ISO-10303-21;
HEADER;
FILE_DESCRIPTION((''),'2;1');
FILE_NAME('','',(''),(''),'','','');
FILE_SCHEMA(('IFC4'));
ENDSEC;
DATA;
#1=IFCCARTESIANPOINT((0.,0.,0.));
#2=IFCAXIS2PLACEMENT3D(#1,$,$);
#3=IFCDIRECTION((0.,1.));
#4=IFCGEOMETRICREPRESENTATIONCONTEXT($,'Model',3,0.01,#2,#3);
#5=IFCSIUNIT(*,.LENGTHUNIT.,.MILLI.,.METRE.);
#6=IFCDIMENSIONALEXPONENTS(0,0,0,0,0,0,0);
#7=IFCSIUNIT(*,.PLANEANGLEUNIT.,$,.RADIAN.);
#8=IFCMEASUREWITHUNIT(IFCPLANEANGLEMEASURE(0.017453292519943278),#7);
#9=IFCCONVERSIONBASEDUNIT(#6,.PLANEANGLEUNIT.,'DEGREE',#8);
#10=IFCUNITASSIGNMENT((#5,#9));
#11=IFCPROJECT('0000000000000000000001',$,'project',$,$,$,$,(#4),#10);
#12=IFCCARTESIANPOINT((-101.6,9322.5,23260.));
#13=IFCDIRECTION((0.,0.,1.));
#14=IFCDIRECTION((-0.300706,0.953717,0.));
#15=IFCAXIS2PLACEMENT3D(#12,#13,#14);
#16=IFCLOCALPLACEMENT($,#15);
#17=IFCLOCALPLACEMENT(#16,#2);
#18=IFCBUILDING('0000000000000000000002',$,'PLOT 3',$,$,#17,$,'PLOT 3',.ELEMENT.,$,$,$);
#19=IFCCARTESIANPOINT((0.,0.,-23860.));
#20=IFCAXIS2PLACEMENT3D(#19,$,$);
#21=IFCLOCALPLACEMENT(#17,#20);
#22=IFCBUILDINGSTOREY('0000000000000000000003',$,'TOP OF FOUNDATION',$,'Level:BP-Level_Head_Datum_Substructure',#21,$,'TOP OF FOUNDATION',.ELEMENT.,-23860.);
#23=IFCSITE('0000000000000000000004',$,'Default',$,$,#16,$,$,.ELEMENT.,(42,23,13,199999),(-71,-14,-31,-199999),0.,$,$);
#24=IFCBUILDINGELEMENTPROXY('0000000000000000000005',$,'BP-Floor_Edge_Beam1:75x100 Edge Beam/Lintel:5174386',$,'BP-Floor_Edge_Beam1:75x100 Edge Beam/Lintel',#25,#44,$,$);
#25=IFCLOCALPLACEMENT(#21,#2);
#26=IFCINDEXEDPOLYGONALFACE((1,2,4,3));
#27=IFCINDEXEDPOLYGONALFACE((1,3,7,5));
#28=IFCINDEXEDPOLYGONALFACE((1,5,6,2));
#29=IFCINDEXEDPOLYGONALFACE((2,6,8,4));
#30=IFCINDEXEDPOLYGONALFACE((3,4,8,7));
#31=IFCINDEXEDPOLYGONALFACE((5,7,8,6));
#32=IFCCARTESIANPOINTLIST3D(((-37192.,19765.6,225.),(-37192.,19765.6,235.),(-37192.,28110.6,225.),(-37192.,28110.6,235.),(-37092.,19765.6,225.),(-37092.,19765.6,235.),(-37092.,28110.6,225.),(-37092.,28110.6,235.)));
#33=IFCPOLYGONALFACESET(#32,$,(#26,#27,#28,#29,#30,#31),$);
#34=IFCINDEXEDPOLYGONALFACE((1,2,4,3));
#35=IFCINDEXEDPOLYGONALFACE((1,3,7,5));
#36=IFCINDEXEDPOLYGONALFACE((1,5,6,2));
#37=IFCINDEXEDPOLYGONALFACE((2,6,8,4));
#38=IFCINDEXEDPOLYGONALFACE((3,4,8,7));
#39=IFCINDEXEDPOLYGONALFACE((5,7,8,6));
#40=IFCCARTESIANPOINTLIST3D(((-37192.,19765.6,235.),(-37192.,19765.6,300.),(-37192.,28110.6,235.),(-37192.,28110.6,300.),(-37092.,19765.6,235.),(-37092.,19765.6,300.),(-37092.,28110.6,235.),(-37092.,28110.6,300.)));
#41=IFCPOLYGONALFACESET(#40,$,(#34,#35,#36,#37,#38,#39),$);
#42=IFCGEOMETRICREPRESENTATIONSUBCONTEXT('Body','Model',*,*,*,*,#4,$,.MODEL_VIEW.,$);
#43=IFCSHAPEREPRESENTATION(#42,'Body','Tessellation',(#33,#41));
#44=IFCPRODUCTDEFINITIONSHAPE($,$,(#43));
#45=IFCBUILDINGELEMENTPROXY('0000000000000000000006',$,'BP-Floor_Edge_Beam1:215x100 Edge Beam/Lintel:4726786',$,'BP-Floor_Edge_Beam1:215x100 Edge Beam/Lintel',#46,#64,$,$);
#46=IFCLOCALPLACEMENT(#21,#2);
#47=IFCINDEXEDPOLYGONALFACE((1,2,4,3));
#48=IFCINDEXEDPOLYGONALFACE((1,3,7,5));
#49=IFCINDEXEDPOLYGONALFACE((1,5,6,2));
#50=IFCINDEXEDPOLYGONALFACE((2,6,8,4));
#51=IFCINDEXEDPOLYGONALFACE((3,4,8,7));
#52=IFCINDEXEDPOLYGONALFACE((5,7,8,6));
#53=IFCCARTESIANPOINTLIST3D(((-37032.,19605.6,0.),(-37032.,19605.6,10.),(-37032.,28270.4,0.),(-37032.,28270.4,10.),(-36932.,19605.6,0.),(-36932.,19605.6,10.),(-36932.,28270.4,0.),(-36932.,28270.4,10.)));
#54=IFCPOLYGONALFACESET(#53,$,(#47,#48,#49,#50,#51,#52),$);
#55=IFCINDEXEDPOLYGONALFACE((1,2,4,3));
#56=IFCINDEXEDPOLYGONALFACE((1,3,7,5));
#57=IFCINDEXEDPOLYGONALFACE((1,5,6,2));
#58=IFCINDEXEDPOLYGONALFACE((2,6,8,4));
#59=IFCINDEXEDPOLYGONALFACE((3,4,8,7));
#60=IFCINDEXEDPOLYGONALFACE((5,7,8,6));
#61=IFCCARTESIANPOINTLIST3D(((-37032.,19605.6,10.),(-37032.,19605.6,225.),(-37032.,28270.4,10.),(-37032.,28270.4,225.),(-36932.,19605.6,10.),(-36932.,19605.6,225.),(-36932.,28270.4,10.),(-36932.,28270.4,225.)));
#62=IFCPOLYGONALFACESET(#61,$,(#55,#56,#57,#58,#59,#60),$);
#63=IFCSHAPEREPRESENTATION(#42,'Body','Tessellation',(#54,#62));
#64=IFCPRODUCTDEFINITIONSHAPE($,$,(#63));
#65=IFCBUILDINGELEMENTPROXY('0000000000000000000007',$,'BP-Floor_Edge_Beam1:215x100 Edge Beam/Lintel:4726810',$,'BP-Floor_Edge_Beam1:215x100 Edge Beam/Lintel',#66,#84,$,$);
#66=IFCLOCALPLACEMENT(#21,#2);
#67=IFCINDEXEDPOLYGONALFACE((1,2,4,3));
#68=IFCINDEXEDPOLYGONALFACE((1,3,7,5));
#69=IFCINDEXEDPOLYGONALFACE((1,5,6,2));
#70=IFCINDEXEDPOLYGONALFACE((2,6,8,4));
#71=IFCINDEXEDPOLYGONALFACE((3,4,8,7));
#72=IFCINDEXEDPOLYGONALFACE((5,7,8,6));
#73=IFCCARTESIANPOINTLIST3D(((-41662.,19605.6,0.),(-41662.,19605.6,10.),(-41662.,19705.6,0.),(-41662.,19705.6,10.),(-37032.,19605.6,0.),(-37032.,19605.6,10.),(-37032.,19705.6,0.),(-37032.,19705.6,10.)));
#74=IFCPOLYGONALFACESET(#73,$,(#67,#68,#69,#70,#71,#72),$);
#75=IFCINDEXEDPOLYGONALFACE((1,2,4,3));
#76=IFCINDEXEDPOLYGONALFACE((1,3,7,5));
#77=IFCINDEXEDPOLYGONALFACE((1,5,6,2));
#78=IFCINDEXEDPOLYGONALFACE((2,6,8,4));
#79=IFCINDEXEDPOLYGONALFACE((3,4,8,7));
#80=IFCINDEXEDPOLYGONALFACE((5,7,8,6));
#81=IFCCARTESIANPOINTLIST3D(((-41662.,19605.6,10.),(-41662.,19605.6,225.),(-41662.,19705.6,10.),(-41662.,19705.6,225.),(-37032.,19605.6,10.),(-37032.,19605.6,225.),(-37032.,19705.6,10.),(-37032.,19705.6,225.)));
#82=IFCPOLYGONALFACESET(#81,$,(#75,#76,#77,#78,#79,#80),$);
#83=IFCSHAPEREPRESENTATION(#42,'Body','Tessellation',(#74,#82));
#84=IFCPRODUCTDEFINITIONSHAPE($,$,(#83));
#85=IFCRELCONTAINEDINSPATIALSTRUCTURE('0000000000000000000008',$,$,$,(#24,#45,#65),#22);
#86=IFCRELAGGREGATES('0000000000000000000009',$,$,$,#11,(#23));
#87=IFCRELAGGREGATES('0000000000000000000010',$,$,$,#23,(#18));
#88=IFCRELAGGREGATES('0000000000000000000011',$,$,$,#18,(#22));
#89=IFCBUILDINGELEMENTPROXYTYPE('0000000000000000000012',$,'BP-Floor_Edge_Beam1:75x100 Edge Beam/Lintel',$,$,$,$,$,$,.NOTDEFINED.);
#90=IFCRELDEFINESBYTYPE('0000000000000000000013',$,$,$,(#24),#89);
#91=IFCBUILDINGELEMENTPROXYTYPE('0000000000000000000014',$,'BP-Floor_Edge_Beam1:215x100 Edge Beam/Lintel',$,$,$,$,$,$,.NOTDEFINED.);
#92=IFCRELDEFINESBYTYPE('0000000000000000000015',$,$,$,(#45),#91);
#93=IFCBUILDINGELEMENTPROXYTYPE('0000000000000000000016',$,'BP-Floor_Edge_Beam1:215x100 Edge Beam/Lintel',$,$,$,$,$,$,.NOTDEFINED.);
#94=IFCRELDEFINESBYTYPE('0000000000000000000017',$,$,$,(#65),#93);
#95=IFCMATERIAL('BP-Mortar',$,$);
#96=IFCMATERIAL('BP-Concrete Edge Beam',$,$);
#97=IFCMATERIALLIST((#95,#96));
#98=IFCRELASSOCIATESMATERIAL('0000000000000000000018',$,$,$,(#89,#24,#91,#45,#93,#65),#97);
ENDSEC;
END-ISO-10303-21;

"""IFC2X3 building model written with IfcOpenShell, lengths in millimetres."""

from ifc_helpers import new_model, entity, si_unit, converted_unit, direction, frame, frame_2d, origin, origin_2d_with_axis, place, context, subcontext, project, spatial, rectangle, extrude, source, transform, mapped, material, material_list, type_object, type_shapes, element, save


model = new_model("IFC2X3")

# Units and contexts
model_context = context("Model", 3, precision=0.01, world=origin(), true_north=direction((0.0, 1.0)))
body_context = subcontext(model_context, "Body", "Model", "MODEL_VIEW")
ifc_project = project(units=[si_unit("LENGTHUNIT", "METRE", prefix="MILLI"), converted_unit("PLANEANGLEUNIT", "DEGREE", entity("IfcPlaneAngleMeasure", 0.017453292519943278), si_unit("PLANEANGLEUNIT", "RADIAN"), dimensions=[0, 0, 0, 0, 0, 0, 0])], contexts=[model_context])

# Site, building, storey
site_placement = place(None, frame((-101.6, 9322.5, 23260.0), z_axis=(0.0, 0.0, 1.0), x_axis=(-0.300706, 0.953717, 0.0)))
site = spatial("IfcSite", under=ifc_project, at=site_placement, Name="Default", CompositionType="ELEMENT", RefLatitude=(42, 23, 13, 199999), RefLongitude=(-71, -14, -31, -199999), RefElevation=0.0)
building_placement = place(site_placement, origin())
building = spatial("IfcBuilding", under=site, at=building_placement, Name="PLOT 3", LongName="PLOT 3", CompositionType="ELEMENT")
storey_placement = place(building_placement, frame((0.0, 0.0, -23860.0)))
storey = spatial("IfcBuildingStorey", under=building, at=storey_placement, Name="TOP OF FOUNDATION", ObjectType="Level:BP-Level_Head_Datum_Substructure", LongName="TOP OF FOUNDATION", CompositionType="ELEMENT", Elevation=-23860.0)

# Building element proxies
ifc_material_1 = material(Name="BP-Mortar")
ifc_material_2 = material(Name="BP-Concrete Edge Beam")
ifc_material_list = material_list([ifc_material_1, ifc_material_2])
building_element_proxy_type_1 = type_object("IfcBuildingElementProxyType", Name="BP-Floor_Edge_Beam1:75x100 Edge Beam/Lintel", PredefinedType="NOTDEFINED", material=ifc_material_list)
shared_shape_1 = source(origin(), body_context, "Body", "SweptSolid", [
    extrude(rectangle(XDim=100.0, YDim=8345.0, at=frame_2d((0.0, 0.0), x_axis=(1.0, 0.0))), frame((0.0, 0.0, 0.0), z_axis=(0.0, 0.0, 1.0), x_axis=(0.0, 1.0, 0.0)), (0.0, 0.0, 1.0), 10.0),
    extrude(rectangle(XDim=100.0, YDim=8345.0, at=origin_2d_with_axis()), frame((0.0, 0.0, 10.0), z_axis=(0.0, 0.0, 1.0), x_axis=(0.0, 1.0, 0.0)), (0.0, 0.0, 1.0), 65.0),
])
type_shapes(building_element_proxy_type_1, [shared_shape_1])
proxy_1_placement = place(storey_placement, frame((-37142.0, 23938.1, 225.0), z_axis=(0.0, 0.0, 1.0), x_axis=(0.0, 1.0, 0.0)))
element("IfcBuildingElementProxy", 1, at=proxy_1_placement, inside=storey, type_object=building_element_proxy_type_1, material=ifc_material_list, Name="BP-Floor_Edge_Beam1:75x100 Edge Beam/Lintel:5174386", ObjectType="BP-Floor_Edge_Beam1:75x100 Edge Beam/Lintel", context=body_context, shape_type="MappedRepresentation", body=[
    mapped(shared_shape_1, transform((0.0, 0.0, 0.0), scale=1.0)),
])
building_element_proxy_type_2 = type_object("IfcBuildingElementProxyType", Name="BP-Floor_Edge_Beam1:215x100 Edge Beam/Lintel", PredefinedType="NOTDEFINED", material=ifc_material_list)
shared_shape_2 = source(origin(), body_context, "Body", "SweptSolid", [
    extrude(rectangle(XDim=100.0, YDim=8664.8, at=frame_2d((0.0, 0.0), x_axis=(1.0, 0.0))), frame((0.0, 0.0, 0.0), z_axis=(0.0, 0.0, 1.0), x_axis=(0.0, 1.0, 0.0)), (0.0, 0.0, 1.0), 10.0),
    extrude(rectangle(XDim=100.0, YDim=8664.8, at=origin_2d_with_axis()), frame((0.0, 0.0, 10.0), z_axis=(0.0, 0.0, 1.0), x_axis=(0.0, 1.0, 0.0)), (0.0, 0.0, 1.0), 215.0),
])
type_shapes(building_element_proxy_type_2, [shared_shape_2])
proxy_2_placement = place(storey_placement, frame((-36982.0, 23938.0, 0.0), z_axis=(0.0, 0.0, 1.0), x_axis=(0.0, 1.0, 0.0)))
element("IfcBuildingElementProxy", 2, at=proxy_2_placement, inside=storey, type_object=building_element_proxy_type_2, material=ifc_material_list, Name="BP-Floor_Edge_Beam1:215x100 Edge Beam/Lintel:4726786", ObjectType="BP-Floor_Edge_Beam1:215x100 Edge Beam/Lintel", context=body_context, shape_type="MappedRepresentation", body=[
    mapped(shared_shape_2, transform((0.0, 0.0, 0.0), scale=1.0)),
])
building_element_proxy_type_3 = type_object("IfcBuildingElementProxyType", Name="BP-Floor_Edge_Beam1:215x100 Edge Beam/Lintel", PredefinedType="NOTDEFINED", material=ifc_material_list)
shared_shape_3 = source(origin(), body_context, "Body", "SweptSolid", [
    extrude(rectangle(XDim=100.0, YDim=4630.0, at=origin_2d_with_axis()), frame((0.0, 0.0, 0.0), z_axis=(0.0, 0.0, 1.0), x_axis=(0.0, 1.0, 0.0)), (0.0, 0.0, 1.0), 10.0),
    extrude(rectangle(XDim=100.0, YDim=4630.0, at=origin_2d_with_axis()), frame((0.0, 0.0, 10.0), z_axis=(0.0, 0.0, 1.0), x_axis=(0.0, 1.0, 0.0)), (0.0, 0.0, 1.0), 215.0),
])
type_shapes(building_element_proxy_type_3, [shared_shape_3])
proxy_3_placement = place(storey_placement, frame((-39347.0, 19655.6, 0.0), z_axis=(0.0, 0.0, 1.0), x_axis=(-1.0, 0.0, 0.0)))
element("IfcBuildingElementProxy", 3, at=proxy_3_placement, inside=storey, type_object=building_element_proxy_type_3, material=ifc_material_list, Name="BP-Floor_Edge_Beam1:215x100 Edge Beam/Lintel:4726810", ObjectType="BP-Floor_Edge_Beam1:215x100 Edge Beam/Lintel", context=body_context, shape_type="MappedRepresentation", body=[
    mapped(shared_shape_3, transform((0.0, 0.0, 0.0), scale=1.0)),
])

save(model, "model.ifc")
